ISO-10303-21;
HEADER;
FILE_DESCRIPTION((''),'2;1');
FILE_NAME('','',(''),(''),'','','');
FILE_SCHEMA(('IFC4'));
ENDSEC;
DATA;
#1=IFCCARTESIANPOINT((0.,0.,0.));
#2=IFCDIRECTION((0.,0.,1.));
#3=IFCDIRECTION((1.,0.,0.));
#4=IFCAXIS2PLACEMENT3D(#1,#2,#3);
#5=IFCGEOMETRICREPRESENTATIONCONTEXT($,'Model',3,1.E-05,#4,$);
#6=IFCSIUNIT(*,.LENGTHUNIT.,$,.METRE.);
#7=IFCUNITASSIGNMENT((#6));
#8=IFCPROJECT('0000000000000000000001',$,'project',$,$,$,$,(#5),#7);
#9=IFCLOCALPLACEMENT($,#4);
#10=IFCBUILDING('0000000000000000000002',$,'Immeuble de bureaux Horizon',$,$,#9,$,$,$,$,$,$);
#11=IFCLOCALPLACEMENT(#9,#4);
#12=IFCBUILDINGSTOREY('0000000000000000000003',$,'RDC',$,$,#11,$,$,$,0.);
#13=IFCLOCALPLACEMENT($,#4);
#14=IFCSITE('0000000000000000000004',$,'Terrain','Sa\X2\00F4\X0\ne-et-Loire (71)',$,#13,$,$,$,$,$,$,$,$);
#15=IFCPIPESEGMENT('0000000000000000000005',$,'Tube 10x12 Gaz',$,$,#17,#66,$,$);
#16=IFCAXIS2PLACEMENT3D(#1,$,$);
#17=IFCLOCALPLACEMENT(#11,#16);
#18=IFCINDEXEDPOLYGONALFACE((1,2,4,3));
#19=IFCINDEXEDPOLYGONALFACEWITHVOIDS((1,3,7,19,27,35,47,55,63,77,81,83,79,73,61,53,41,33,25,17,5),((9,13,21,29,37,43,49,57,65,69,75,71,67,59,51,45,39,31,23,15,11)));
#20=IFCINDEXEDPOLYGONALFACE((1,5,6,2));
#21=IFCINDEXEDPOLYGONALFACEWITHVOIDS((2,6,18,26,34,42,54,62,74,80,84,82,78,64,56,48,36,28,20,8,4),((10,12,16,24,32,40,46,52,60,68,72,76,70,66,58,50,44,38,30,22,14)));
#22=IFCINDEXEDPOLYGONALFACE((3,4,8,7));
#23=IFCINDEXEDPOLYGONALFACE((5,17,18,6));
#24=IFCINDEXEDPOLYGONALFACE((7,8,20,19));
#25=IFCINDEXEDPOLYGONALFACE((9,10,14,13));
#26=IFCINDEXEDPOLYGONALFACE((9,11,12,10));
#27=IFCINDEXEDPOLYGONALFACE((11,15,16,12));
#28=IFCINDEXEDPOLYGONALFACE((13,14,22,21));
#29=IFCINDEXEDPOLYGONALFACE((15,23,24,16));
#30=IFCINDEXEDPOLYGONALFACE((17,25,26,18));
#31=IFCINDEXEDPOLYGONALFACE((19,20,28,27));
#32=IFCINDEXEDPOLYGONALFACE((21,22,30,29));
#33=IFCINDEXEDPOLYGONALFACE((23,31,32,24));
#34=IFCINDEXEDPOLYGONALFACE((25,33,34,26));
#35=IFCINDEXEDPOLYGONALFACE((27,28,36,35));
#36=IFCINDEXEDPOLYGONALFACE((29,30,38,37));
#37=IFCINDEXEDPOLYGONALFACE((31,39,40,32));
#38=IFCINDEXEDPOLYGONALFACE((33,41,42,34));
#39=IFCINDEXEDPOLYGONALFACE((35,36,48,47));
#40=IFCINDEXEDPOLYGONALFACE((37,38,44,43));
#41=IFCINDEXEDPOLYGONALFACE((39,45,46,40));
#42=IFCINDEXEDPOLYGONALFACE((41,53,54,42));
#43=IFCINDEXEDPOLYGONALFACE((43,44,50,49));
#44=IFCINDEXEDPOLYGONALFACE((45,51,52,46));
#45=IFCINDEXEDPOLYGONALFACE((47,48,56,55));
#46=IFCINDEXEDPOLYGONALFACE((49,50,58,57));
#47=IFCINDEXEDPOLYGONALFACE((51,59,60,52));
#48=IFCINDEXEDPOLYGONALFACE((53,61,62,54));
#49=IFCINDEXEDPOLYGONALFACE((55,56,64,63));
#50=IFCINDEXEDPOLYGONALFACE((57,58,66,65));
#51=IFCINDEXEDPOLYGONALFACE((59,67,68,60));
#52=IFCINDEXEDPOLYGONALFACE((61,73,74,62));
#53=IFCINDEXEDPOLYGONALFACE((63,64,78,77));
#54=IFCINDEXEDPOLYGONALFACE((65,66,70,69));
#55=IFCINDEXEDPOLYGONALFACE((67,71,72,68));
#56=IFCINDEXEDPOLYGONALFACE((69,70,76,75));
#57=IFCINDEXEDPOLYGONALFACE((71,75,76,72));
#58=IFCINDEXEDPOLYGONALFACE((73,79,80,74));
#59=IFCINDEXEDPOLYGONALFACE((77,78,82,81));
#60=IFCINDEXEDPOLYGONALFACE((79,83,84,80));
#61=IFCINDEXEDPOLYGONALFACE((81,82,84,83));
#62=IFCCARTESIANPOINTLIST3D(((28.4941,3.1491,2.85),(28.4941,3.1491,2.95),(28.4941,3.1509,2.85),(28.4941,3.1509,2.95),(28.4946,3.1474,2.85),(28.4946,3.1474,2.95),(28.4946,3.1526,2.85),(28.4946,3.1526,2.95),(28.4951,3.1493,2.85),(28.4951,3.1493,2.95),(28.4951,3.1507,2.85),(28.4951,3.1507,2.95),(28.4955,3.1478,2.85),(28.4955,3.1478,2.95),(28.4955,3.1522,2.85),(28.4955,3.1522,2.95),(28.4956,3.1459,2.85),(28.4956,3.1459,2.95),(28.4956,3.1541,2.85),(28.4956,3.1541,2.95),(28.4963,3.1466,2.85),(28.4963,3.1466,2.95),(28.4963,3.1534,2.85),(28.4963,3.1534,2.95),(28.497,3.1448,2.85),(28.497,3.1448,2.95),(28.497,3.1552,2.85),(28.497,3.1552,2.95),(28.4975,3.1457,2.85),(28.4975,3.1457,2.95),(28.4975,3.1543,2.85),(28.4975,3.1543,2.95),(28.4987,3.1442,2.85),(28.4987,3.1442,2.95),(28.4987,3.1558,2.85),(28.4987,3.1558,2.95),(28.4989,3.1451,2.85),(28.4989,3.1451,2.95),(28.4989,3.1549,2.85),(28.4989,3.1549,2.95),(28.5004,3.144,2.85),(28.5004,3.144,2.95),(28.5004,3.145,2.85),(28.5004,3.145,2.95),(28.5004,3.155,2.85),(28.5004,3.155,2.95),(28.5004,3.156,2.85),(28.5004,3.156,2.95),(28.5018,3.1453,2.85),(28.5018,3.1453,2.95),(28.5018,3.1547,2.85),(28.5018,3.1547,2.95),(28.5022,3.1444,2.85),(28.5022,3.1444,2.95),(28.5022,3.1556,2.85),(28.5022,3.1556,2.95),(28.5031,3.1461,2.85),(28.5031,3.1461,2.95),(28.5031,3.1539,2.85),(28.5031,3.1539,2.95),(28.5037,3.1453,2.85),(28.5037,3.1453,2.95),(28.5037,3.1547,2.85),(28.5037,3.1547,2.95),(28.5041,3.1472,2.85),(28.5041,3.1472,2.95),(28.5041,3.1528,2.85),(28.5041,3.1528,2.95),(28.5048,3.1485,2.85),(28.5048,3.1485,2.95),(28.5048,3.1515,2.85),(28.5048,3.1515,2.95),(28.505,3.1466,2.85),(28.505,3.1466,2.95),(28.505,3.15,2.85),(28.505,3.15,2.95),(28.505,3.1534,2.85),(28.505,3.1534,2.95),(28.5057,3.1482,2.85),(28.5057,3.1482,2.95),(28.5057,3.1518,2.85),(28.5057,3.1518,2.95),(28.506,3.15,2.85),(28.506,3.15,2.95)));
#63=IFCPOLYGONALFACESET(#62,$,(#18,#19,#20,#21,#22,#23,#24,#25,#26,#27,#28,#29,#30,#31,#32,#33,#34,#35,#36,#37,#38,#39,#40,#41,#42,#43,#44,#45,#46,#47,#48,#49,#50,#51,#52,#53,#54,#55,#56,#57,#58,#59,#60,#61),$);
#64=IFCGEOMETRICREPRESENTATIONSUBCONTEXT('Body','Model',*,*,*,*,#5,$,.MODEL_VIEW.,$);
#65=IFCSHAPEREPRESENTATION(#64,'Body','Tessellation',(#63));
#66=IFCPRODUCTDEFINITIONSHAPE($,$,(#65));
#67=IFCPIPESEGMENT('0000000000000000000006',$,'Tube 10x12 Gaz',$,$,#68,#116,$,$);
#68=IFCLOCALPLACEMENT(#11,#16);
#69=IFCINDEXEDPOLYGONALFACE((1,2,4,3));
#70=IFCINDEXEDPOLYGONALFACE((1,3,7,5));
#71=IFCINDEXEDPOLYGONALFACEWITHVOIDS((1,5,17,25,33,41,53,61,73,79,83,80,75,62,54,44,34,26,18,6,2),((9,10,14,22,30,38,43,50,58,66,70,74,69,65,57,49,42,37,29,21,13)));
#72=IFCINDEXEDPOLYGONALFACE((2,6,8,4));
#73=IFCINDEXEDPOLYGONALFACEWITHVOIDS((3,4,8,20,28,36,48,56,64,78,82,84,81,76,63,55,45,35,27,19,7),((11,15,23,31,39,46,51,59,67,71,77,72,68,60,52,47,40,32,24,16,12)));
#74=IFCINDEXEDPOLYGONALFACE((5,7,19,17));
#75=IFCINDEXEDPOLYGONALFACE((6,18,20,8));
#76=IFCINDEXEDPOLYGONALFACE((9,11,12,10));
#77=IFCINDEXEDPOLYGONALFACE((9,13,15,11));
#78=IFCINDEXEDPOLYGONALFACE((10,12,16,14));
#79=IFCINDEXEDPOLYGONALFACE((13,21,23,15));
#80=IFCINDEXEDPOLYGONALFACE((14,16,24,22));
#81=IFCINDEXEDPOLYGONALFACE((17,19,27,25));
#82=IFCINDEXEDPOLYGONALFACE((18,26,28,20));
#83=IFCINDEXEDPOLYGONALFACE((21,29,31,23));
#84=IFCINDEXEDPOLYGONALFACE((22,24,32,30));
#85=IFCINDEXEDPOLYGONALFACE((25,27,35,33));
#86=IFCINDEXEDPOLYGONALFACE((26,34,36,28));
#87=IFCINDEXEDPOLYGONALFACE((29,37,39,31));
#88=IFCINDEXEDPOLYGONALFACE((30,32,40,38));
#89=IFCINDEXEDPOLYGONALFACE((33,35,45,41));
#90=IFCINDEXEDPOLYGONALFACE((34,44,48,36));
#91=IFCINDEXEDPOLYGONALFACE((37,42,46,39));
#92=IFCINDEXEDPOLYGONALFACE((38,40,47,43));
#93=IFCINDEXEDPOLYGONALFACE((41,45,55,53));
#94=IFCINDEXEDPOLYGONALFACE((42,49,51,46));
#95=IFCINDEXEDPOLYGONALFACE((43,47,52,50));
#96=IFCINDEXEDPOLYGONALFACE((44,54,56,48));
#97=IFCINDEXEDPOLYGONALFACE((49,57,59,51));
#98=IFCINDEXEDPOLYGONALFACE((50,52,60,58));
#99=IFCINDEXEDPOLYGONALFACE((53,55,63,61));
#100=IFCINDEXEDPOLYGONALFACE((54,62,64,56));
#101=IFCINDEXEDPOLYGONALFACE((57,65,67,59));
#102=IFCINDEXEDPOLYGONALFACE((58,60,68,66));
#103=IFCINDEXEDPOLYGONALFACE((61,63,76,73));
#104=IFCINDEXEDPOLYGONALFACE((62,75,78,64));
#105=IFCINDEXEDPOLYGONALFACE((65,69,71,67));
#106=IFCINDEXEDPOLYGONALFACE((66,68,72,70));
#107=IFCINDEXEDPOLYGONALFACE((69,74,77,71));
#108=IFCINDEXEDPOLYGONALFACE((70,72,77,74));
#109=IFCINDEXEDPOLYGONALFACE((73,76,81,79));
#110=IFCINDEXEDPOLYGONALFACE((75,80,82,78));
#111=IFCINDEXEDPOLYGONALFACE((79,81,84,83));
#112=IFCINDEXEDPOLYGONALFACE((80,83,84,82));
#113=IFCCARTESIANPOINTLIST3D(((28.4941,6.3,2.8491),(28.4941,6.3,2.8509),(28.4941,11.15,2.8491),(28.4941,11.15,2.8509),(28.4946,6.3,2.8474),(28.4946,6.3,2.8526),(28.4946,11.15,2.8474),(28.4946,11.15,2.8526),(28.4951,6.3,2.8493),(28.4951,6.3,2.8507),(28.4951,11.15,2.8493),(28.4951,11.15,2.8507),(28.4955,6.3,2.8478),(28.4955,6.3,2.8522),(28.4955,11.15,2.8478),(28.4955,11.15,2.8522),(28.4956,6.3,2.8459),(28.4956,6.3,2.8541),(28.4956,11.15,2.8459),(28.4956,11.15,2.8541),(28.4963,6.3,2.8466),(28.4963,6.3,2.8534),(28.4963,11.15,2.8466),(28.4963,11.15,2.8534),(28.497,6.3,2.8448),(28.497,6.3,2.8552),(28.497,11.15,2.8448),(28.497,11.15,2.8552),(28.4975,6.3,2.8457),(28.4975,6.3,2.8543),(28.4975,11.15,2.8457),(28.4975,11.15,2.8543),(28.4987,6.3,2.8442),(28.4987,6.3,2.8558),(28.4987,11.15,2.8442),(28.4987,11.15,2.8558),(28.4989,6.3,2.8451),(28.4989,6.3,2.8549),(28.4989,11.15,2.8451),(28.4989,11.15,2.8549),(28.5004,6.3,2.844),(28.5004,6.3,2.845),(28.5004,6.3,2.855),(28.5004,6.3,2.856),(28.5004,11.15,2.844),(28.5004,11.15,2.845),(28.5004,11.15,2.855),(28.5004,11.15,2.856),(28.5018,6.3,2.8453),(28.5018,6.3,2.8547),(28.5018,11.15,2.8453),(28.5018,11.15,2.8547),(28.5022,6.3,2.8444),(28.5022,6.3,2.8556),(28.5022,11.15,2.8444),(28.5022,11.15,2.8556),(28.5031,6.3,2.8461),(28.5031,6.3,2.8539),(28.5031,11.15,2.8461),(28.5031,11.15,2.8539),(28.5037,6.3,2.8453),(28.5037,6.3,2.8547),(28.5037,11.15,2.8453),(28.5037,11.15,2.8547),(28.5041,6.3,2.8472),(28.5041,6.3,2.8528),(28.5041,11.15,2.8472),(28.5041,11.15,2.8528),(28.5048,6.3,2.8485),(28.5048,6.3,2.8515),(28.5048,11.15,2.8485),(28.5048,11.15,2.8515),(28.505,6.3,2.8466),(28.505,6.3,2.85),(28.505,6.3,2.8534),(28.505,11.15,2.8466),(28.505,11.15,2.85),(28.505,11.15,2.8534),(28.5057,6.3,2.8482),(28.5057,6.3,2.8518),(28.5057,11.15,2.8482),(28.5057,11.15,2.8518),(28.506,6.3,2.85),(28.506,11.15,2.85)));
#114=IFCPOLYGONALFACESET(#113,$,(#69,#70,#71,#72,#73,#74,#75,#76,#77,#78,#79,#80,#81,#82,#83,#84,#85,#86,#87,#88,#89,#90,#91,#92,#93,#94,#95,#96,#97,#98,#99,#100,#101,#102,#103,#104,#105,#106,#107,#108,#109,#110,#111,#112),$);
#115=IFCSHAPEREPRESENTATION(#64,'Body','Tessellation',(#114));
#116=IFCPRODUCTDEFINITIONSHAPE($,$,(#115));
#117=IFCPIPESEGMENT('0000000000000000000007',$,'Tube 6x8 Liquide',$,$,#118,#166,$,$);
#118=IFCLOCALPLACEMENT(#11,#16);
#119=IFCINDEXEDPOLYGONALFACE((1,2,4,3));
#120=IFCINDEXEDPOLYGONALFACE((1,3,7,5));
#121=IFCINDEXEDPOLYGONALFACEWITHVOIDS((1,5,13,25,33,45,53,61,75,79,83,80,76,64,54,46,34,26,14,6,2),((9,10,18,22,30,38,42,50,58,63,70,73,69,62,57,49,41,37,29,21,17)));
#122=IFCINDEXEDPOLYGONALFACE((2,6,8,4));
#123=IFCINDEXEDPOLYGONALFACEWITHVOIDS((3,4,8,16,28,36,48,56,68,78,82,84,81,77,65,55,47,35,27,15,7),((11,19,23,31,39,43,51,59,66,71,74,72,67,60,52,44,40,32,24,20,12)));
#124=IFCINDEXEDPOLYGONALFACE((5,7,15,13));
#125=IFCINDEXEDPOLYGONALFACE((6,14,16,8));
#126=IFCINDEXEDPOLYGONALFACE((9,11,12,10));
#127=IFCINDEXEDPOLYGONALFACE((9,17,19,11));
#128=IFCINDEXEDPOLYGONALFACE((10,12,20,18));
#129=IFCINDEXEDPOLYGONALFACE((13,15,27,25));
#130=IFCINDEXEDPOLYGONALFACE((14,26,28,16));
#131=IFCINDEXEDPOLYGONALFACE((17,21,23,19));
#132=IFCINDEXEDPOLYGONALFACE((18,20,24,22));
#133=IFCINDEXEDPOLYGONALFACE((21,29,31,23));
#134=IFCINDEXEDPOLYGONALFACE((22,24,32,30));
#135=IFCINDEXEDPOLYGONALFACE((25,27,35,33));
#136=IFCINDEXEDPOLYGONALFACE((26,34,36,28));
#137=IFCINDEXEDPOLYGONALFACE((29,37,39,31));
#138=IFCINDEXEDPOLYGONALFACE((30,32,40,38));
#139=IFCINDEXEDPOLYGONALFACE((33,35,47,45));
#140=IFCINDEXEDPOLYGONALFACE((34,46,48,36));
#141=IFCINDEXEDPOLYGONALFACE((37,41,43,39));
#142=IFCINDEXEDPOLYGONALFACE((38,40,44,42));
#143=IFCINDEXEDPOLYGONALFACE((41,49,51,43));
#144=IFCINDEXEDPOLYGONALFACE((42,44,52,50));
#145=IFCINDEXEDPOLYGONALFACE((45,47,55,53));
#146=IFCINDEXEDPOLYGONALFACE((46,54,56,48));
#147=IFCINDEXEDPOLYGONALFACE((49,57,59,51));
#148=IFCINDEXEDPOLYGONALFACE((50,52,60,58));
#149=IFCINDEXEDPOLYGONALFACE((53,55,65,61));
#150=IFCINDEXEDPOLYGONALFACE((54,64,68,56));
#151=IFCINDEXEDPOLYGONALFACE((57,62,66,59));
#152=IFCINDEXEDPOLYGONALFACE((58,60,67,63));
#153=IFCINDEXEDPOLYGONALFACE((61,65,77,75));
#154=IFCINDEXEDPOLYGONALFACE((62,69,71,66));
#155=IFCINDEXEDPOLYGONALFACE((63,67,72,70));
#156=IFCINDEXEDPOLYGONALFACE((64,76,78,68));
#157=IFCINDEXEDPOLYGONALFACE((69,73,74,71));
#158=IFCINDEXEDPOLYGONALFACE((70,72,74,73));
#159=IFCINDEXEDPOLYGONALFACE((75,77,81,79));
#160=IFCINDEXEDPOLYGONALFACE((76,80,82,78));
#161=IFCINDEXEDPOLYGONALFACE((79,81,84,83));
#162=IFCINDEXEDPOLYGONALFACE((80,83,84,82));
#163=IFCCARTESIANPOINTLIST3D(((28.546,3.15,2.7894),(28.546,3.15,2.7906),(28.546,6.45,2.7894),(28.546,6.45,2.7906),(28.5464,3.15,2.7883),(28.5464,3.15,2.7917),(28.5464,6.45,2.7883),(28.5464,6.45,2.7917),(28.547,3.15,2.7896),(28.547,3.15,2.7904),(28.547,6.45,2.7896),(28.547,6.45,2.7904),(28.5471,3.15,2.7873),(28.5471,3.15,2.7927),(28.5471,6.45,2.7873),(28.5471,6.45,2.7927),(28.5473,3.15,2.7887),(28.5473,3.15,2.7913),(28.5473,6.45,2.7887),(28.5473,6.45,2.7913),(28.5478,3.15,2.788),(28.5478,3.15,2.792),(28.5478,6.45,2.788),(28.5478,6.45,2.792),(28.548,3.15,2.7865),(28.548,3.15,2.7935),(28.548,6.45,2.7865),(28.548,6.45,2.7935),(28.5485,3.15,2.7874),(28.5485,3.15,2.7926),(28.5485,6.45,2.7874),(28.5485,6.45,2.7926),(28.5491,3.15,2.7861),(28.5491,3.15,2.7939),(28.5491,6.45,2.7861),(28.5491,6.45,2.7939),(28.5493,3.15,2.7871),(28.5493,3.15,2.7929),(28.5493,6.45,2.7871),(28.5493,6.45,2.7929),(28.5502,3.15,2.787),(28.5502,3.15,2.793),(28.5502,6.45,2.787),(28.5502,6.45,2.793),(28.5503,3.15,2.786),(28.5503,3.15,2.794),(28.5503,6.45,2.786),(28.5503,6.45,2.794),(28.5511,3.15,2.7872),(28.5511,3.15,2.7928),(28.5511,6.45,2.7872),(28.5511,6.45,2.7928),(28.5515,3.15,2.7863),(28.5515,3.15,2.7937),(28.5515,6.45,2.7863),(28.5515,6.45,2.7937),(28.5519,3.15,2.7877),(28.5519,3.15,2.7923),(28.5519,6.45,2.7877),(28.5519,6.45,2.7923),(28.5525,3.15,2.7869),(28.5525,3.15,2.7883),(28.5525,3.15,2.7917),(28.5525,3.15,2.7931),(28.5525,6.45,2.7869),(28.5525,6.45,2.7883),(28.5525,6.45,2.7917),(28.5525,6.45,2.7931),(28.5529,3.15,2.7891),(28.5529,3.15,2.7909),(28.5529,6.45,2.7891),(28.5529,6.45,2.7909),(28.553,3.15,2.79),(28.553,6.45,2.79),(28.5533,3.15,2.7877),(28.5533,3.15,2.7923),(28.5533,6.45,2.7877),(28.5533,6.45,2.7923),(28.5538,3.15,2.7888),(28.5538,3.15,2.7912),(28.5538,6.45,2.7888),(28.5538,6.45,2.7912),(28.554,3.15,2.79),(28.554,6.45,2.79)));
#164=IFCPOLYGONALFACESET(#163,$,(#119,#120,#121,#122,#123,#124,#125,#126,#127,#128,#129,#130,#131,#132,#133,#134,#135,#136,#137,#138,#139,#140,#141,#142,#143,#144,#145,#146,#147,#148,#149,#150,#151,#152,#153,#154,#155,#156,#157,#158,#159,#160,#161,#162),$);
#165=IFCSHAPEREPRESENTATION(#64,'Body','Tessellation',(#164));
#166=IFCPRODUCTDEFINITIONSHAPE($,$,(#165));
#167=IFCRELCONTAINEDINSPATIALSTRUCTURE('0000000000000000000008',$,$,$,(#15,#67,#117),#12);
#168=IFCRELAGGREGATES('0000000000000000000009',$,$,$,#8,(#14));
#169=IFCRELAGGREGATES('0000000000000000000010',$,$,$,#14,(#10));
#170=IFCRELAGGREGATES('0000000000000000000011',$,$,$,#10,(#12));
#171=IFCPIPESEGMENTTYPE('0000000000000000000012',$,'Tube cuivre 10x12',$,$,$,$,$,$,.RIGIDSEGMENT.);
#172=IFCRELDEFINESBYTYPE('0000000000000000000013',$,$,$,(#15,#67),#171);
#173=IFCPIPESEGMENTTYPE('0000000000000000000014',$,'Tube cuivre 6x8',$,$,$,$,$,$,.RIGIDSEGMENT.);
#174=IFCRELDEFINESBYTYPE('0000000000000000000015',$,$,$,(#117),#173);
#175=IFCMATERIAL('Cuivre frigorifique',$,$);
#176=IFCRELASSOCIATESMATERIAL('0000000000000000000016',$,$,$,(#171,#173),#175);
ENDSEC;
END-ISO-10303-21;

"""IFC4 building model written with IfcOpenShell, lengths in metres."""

from ifc_helpers import new_model, si_unit, frame, origin_with_axes, place, context, subcontext, project, spatial, hollow_circle, extrude, material, type_object, element, save


model = new_model("IFC4")

# Units and contexts
model_context = context("Model", 3, precision=1e-05, world=origin_with_axes())
body_context = subcontext(model_context, "Body", "Model", "MODEL_VIEW")
ifc_project = project(units=[si_unit("LENGTHUNIT", "METRE")], contexts=[model_context])

# Site, building, storey
site_placement = place(None, origin_with_axes())
site = spatial("IfcSite", under=ifc_project, at=site_placement, Name="Terrain", Description="Saône-et-Loire (71)")
building_placement = place(None, origin_with_axes())
building = spatial("IfcBuilding", under=site, at=building_placement, Name="Immeuble de bureaux Horizon")
storey_placement = place(building_placement, origin_with_axes())
storey = spatial("IfcBuildingStorey", under=building, at=storey_placement, Name="RDC", Elevation=0.0)

# Shared definitions
ifc_material_1 = material(Name="Cuivre frigorifique")

# Pipe segments
pipe_segment_type_1 = type_object("IfcPipeSegmentType", Name="Tube cuivre 10x12", PredefinedType="RIGIDSEGMENT", material=ifc_material_1)
pipe_segment_1_placement = place(storey_placement, frame((28.5, 3.15, 2.85), z_axis=(0.0, 0.0, 1.0), x_axis=(1.0, 0.0, 0.0)))
element("IfcPipeSegment", 1, at=pipe_segment_1_placement, inside=storey, type_object=pipe_segment_type_1, Name="Tube 10x12 Gaz", context=body_context, shape_type="SweptSolid", body=[
    extrude(hollow_circle(Radius=0.006, WallThickness=0.001), origin_with_axes(), (0.0, 0.0, 1.0), 0.1),
])
pipe_segment_2_placement = place(storey_placement, frame((28.5, 6.3, 2.85), z_axis=(0.0, 1.0, 0.0), x_axis=(1.0, 0.0, 0.0)))
element("IfcPipeSegment", 2, at=pipe_segment_2_placement, inside=storey, type_object=pipe_segment_type_1, Name="Tube 10x12 Gaz", context=body_context, shape_type="SweptSolid", body=[
    extrude(hollow_circle(Radius=0.006, WallThickness=0.001), origin_with_axes(), (0.0, 0.0, 1.0), 4.85),
])
pipe_segment_type_2 = type_object("IfcPipeSegmentType", Name="Tube cuivre 6x8", PredefinedType="RIGIDSEGMENT", material=ifc_material_1)
pipe_segment_3_placement = place(storey_placement, frame((28.55, 6.45, 2.79), z_axis=(0.0, -1.0, 0.0), x_axis=(1.0, 0.0, 0.0)))
element("IfcPipeSegment", 3, at=pipe_segment_3_placement, inside=storey, type_object=pipe_segment_type_2, Name="Tube 6x8 Liquide", context=body_context, shape_type="SweptSolid", body=[
    extrude(hollow_circle(Radius=0.004, WallThickness=0.001), origin_with_axes(), (0.0, 0.0, 1.0), 3.3),
])

save(model, "model.ifc")
